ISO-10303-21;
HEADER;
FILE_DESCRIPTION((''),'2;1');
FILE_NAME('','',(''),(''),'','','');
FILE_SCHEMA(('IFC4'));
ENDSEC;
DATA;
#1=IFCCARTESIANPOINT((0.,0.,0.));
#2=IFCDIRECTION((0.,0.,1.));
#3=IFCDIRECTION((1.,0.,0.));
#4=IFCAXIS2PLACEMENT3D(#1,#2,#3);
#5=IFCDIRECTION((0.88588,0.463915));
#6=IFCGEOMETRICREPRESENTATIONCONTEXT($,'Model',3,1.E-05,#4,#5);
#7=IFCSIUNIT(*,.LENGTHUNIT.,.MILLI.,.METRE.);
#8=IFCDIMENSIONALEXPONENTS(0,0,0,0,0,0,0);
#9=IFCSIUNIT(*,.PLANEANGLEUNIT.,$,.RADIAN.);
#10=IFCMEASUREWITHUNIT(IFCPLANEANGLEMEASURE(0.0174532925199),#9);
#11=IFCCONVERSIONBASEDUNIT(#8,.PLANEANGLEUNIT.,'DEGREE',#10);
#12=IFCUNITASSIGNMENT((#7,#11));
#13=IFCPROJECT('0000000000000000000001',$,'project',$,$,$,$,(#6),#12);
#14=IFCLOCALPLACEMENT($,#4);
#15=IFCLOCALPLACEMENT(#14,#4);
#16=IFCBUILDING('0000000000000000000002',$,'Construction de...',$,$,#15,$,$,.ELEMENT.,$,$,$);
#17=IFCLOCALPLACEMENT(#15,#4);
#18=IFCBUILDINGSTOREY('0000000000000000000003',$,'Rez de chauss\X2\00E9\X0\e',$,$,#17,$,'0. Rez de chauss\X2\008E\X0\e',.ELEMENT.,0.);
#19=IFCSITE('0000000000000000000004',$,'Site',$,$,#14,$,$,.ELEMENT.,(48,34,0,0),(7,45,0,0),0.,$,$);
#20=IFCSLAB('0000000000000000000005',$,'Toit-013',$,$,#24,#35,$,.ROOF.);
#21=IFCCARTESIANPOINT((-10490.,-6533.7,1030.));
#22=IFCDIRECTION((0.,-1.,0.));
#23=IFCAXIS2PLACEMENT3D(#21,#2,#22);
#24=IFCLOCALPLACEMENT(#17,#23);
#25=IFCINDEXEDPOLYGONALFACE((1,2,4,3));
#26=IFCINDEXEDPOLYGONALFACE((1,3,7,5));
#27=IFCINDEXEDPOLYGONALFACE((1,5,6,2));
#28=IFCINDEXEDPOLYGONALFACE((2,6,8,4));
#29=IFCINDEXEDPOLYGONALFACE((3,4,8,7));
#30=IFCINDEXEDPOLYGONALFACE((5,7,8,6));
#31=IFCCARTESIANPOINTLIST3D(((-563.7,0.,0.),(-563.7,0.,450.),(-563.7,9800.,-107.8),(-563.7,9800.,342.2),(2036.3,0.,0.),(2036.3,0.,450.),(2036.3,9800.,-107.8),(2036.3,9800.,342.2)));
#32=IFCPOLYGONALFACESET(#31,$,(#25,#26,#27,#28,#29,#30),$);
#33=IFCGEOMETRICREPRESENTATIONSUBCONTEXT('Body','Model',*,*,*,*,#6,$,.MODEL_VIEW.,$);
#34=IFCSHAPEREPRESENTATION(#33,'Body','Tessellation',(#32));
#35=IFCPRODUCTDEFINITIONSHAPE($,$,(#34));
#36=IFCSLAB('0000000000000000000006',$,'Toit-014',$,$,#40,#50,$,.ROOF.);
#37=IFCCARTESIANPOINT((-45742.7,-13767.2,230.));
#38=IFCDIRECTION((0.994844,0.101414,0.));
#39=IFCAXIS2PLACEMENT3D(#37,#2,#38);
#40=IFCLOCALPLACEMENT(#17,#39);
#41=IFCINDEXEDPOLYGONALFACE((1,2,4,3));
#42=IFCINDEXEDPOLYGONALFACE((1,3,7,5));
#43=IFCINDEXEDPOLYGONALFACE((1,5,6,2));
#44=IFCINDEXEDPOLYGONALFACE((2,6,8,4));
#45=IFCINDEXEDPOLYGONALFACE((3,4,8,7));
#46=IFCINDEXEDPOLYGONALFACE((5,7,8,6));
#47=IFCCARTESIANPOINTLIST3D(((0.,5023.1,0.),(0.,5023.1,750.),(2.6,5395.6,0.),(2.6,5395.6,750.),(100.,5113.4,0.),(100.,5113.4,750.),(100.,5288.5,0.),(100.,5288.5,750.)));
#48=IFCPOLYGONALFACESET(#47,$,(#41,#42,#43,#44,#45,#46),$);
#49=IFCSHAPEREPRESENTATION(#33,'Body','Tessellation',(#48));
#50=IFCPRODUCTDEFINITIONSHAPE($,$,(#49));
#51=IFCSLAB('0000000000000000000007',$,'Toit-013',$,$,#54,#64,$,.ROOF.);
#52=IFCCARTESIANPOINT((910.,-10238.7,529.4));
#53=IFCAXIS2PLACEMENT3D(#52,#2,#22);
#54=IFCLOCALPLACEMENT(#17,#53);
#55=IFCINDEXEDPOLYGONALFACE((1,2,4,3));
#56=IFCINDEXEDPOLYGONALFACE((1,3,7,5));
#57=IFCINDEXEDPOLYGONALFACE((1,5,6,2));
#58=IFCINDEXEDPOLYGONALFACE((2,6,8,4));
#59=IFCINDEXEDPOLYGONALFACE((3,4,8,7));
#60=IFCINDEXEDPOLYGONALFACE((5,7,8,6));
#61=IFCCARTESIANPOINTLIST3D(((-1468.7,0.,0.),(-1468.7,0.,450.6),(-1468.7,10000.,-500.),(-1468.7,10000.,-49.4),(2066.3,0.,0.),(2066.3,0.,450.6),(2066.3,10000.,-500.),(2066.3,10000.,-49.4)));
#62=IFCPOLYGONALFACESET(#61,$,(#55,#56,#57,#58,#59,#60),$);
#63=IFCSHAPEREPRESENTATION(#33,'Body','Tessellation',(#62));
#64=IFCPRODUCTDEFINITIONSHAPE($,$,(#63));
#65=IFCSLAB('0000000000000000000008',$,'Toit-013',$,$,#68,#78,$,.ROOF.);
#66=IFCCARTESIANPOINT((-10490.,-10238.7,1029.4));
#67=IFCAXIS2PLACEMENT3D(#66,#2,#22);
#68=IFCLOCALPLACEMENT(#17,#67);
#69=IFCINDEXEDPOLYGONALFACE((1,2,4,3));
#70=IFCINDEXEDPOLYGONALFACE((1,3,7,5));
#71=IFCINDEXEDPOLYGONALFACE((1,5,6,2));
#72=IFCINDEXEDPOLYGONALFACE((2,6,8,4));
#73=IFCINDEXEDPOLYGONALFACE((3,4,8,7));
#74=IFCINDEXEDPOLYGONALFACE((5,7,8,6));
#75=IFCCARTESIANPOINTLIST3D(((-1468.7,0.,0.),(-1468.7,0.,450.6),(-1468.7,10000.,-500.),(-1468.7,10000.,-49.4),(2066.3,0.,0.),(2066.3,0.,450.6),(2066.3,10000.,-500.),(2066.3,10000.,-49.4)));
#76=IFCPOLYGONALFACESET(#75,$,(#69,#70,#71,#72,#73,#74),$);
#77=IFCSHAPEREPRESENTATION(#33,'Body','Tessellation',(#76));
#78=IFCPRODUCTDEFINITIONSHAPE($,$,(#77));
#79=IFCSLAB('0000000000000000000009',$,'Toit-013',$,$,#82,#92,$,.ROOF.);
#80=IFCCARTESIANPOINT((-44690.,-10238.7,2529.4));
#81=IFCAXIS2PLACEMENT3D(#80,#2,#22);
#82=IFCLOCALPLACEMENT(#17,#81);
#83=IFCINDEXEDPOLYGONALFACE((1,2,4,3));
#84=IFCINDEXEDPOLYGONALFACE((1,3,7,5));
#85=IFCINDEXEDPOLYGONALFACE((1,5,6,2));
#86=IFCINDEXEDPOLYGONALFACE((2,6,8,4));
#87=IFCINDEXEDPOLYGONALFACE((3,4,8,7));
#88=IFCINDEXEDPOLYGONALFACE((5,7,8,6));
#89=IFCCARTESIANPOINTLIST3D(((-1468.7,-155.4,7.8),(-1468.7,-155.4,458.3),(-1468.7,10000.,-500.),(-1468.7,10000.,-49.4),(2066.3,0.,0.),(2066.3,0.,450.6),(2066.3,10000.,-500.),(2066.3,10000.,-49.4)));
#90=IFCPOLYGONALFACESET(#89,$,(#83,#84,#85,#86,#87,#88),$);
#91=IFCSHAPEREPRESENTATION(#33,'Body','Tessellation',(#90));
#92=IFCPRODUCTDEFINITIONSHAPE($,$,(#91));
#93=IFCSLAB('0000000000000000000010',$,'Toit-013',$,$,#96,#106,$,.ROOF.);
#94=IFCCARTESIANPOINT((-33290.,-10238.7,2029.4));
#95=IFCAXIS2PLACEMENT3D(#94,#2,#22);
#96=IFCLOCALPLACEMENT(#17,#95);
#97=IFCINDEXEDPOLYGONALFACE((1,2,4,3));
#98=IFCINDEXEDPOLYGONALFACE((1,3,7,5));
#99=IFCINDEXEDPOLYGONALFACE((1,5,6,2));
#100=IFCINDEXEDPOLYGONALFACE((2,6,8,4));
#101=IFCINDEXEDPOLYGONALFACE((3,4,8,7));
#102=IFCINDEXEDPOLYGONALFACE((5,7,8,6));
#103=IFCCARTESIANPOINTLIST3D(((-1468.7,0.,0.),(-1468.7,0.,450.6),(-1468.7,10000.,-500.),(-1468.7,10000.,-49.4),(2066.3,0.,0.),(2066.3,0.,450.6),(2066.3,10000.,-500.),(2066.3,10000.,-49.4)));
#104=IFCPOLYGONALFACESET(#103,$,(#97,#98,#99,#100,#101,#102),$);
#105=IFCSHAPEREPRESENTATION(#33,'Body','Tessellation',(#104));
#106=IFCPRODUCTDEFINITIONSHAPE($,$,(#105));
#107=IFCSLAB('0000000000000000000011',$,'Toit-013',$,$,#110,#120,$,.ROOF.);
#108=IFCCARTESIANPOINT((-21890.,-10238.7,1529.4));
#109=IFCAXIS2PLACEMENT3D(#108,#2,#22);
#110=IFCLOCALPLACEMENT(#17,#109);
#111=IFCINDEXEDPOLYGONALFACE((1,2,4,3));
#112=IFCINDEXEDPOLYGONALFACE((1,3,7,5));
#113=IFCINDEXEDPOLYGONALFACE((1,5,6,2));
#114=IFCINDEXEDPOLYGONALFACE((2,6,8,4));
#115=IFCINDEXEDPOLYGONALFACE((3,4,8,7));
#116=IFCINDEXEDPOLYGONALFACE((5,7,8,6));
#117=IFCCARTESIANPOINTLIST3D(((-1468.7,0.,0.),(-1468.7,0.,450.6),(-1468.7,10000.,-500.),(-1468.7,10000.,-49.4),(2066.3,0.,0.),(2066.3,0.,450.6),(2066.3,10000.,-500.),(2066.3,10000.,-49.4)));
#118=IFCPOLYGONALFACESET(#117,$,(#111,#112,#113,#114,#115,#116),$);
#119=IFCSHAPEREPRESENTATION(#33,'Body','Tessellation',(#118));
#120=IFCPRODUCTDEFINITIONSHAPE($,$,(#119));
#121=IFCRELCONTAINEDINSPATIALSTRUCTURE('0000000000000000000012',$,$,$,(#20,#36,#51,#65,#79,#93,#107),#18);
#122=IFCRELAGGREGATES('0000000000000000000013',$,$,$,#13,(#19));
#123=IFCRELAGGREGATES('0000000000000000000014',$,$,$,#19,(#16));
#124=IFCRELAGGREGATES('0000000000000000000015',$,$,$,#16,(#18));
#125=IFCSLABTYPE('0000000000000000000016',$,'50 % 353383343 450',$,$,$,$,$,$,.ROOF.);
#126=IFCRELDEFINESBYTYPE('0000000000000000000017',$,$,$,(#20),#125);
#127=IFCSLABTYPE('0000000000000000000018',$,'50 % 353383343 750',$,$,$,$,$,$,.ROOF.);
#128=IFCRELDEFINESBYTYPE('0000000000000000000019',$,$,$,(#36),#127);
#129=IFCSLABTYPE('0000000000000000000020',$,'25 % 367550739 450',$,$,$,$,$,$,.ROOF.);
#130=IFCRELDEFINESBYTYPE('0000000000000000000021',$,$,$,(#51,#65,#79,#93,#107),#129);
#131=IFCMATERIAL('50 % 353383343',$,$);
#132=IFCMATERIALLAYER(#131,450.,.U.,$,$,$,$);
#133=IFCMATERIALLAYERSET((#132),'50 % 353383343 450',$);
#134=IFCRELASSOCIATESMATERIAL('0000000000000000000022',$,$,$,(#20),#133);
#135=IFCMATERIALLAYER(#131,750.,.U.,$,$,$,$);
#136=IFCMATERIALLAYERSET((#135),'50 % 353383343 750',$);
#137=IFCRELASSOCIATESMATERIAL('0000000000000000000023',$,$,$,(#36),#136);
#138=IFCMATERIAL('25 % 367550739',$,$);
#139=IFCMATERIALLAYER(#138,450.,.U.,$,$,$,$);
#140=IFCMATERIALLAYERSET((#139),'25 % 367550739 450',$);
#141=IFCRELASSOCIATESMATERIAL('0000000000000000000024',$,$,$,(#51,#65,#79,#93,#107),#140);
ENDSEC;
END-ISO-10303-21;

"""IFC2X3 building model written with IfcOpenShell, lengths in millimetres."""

from ifc_helpers import new_model, entity, si_unit, converted_unit, direction, frame, origin_with_axes, place, context, subcontext, project, spatial, polyline, outline, extrude, material, layer, layer_set, layer_usage, type_object, element, save


model = new_model("IFC2X3")

# Units and contexts
model_context = context("Model", 3, precision=1e-05, world=origin_with_axes(), true_north=direction((0.88588, 0.463915)))
body_context = subcontext(model_context, "Body", "Model", "MODEL_VIEW")
ifc_project = project(units=[si_unit("LENGTHUNIT", "METRE", prefix="MILLI"), converted_unit("PLANEANGLEUNIT", "DEGREE", entity("IfcPlaneAngleMeasure", 0.0174532925199), si_unit("PLANEANGLEUNIT", "RADIAN"), dimensions=[0, 0, 0, 0, 0, 0, 0])], contexts=[model_context])

# Site, building, storey
site_placement = place(None, origin_with_axes())
site = spatial("IfcSite", under=ifc_project, at=site_placement, Name="Site", CompositionType="ELEMENT", RefLatitude=(48, 34, 0, 0), RefLongitude=(7, 45, 0, 0), RefElevation=0.0)
building_placement = place(site_placement, origin_with_axes())
building = spatial("IfcBuilding", under=site, at=building_placement, Name="Construction de...", CompositionType="ELEMENT")
storey_placement = place(building_placement, origin_with_axes())
storey = spatial("IfcBuildingStorey", under=building, at=storey_placement, Name="Rez de chaussée", LongName="0. Rez de chauss\u008ee", CompositionType="ELEMENT", Elevation=0.0)

# Slabs
ifc_material_1 = material(Name="25 % 367550739")
ifc_material_2 = material(Name="50 % 353383343")
ifc_layer_1 = layer(ifc_material_2, 450.0, ventilated="UNKNOWN")
ifc_layer_set_1 = layer_set([ifc_layer_1], Name="50 % 353383343 450")
ifc_layer_usage_1 = layer_usage(ifc_layer_set_1, "AXIS3", "NEGATIVE", 450.0)
slab_type_1 = type_object("IfcSlabType", Name="50 % 353383343 450", PredefinedType="ROOF")
slab_1_placement = place(storey_placement, frame((-10490.0, -6533.7, 1030.0), z_axis=(0.0, 0.0, 1.0), x_axis=(0.0, -1.0, 0.0)))
element("IfcSlab", 1, at=slab_1_placement, inside=storey, type_object=slab_type_1, material=ifc_layer_usage_1, Name="Toit-013", PredefinedType="ROOF", context=body_context, shape_type="SweptSolid", body=[
    extrude(outline(polyline([(2036.3, 0.0), (2036.3, 9800.6), (-563.7, 9800.6), (-563.7, 0.0), (2036.3, 0.0)])), frame((0.0, 0.0, 0.0), z_axis=(0.0, 0.010999, 0.99994), x_axis=(1.0, 0.0, 0.0)), (0.0, -0.010999, 0.99994), 450.0),
])
ifc_layer_2 = layer(ifc_material_2, 750.0, ventilated="UNKNOWN")
ifc_layer_set_2 = layer_set([ifc_layer_2], Name="50 % 353383343 750")
ifc_layer_usage_2 = layer_usage(ifc_layer_set_2, "AXIS3", "NEGATIVE", 750.0)
slab_type_2 = type_object("IfcSlabType", Name="50 % 353383343 750", PredefinedType="ROOF")
slab_2_placement = place(storey_placement, frame((-45742.7, -13767.2, 230.0), z_axis=(0.0, 0.0, 1.0), x_axis=(0.994844, 0.101414, 0.0)))
element("IfcSlab", 2, at=slab_2_placement, inside=storey, type_object=slab_type_2, material=ifc_layer_usage_2, Name="Toit-014", PredefinedType="ROOF", context=body_context, shape_type="SweptSolid", body=[
    extrude(outline(polyline([(100.0, 5113.4), (100.0, 5288.5), (2.6, 5395.6), (0.0, 5023.1), (100.0, 5113.4)])), origin_with_axes(), (0.0, 0.0, 1.0), 750.0),
])
ifc_layer_3 = layer(ifc_material_1, 450.0, ventilated="UNKNOWN")
ifc_layer_set_3 = layer_set([ifc_layer_3], Name="25 % 367550739 450")
ifc_layer_usage_3 = layer_usage(ifc_layer_set_3, "AXIS3", "NEGATIVE", 450.0)
slab_type_3 = type_object("IfcSlabType", Name="25 % 367550739 450", PredefinedType="ROOF")
slab_3_placement = place(storey_placement, frame((910.0, -10238.7, 529.4), z_axis=(0.0, 0.0, 1.0), x_axis=(0.0, -1.0, 0.0)))
element("IfcSlab", 3, at=slab_3_placement, inside=storey, type_object=slab_type_3, material=ifc_layer_usage_3, Name="Toit-013", PredefinedType="ROOF", context=body_context, shape_type="SweptSolid", body=[
    extrude(outline(polyline([(2066.3, 0.0), (2066.3, 10012.5), (-1468.7, 10012.5), (-1468.7, 0.0), (2066.3, 0.0)])), frame((0.0, 0.0, 0.0), z_axis=(0.0, 0.049938, 0.998752), x_axis=(1.0, 0.0, 0.0)), (0.0, -0.049938, 0.998752), 450.6),
])
ifc_layer_usage_4 = layer_usage(ifc_layer_set_3, "AXIS3", "NEGATIVE", 450.0)
slab_4_placement = place(storey_placement, frame((-10490.0, -10238.7, 1029.4), z_axis=(0.0, 0.0, 1.0), x_axis=(0.0, -1.0, 0.0)))
element("IfcSlab", 4, at=slab_4_placement, inside=storey, type_object=slab_type_3, material=ifc_layer_usage_4, Name="Toit-013", PredefinedType="ROOF", context=body_context, shape_type="SweptSolid", body=[
    extrude(outline(polyline([(2066.3, 0.0), (2066.3, 10012.5), (-1468.7, 10012.5), (-1468.7, 0.0), (2066.3, 0.0)])), frame((0.0, 0.0, 0.0), z_axis=(0.0, 0.049938, 0.998752), x_axis=(1.0, 0.0, 0.0)), (0.0, -0.049938, 0.998752), 450.6),
])
ifc_layer_usage_5 = layer_usage(ifc_layer_set_3, "AXIS3", "NEGATIVE", 450.0)
slab_5_placement = place(storey_placement, frame((-44690.0, -10238.7, 2529.4), z_axis=(0.0, 0.0, 1.0), x_axis=(0.0, -1.0, 0.0)))
element("IfcSlab", 5, at=slab_5_placement, inside=storey, type_object=slab_type_3, material=ifc_layer_usage_5, Name="Toit-013", PredefinedType="ROOF", context=body_context, shape_type="SweptSolid", body=[
    extrude(outline(polyline([(2066.3, 0.0), (2066.3, 10012.5), (-1468.7, 10012.5), (-1468.7, -155.6), (2066.3, 0.0)])), frame((0.0, 0.0, 0.0), z_axis=(0.0, 0.049938, 0.998752), x_axis=(1.0, 0.0, 0.0)), (0.0, -0.049938, 0.998752), 450.6),
])
ifc_layer_usage_6 = layer_usage(ifc_layer_set_3, "AXIS3", "NEGATIVE", 450.0)
slab_6_placement = place(storey_placement, frame((-33290.0, -10238.7, 2029.4), z_axis=(0.0, 0.0, 1.0), x_axis=(0.0, -1.0, 0.0)))
element("IfcSlab", 6, at=slab_6_placement, inside=storey, type_object=slab_type_3, material=ifc_layer_usage_6, Name="Toit-013", PredefinedType="ROOF", context=body_context, shape_type="SweptSolid", body=[
    extrude(outline(polyline([(2066.3, 0.0), (2066.3, 10012.5), (-1468.7, 10012.5), (-1468.7, 0.0), (2066.3, 0.0)])), frame((0.0, 0.0, 0.0), z_axis=(0.0, 0.049938, 0.998752), x_axis=(1.0, 0.0, 0.0)), (0.0, -0.049938, 0.998752), 450.6),
])
ifc_layer_usage_7 = layer_usage(ifc_layer_set_3, "AXIS3", "NEGATIVE", 450.0)
slab_7_placement = place(storey_placement, frame((-21890.0, -10238.7, 1529.4), z_axis=(0.0, 0.0, 1.0), x_axis=(0.0, -1.0, 0.0)))
element("IfcSlab", 7, at=slab_7_placement, inside=storey, type_object=slab_type_3, material=ifc_layer_usage_7, Name="Toit-013", PredefinedType="ROOF", context=body_context, shape_type="SweptSolid", body=[
    extrude(outline(polyline([(2066.3, 0.0), (2066.3, 10012.5), (-1468.7, 10012.5), (-1468.7, 0.0), (2066.3, 0.0)])), frame((0.0, 0.0, 0.0), z_axis=(0.0, 0.049938, 0.998752), x_axis=(1.0, 0.0, 0.0)), (0.0, -0.049938, 0.998752), 450.6),
])

save(model, "model.ifc")
